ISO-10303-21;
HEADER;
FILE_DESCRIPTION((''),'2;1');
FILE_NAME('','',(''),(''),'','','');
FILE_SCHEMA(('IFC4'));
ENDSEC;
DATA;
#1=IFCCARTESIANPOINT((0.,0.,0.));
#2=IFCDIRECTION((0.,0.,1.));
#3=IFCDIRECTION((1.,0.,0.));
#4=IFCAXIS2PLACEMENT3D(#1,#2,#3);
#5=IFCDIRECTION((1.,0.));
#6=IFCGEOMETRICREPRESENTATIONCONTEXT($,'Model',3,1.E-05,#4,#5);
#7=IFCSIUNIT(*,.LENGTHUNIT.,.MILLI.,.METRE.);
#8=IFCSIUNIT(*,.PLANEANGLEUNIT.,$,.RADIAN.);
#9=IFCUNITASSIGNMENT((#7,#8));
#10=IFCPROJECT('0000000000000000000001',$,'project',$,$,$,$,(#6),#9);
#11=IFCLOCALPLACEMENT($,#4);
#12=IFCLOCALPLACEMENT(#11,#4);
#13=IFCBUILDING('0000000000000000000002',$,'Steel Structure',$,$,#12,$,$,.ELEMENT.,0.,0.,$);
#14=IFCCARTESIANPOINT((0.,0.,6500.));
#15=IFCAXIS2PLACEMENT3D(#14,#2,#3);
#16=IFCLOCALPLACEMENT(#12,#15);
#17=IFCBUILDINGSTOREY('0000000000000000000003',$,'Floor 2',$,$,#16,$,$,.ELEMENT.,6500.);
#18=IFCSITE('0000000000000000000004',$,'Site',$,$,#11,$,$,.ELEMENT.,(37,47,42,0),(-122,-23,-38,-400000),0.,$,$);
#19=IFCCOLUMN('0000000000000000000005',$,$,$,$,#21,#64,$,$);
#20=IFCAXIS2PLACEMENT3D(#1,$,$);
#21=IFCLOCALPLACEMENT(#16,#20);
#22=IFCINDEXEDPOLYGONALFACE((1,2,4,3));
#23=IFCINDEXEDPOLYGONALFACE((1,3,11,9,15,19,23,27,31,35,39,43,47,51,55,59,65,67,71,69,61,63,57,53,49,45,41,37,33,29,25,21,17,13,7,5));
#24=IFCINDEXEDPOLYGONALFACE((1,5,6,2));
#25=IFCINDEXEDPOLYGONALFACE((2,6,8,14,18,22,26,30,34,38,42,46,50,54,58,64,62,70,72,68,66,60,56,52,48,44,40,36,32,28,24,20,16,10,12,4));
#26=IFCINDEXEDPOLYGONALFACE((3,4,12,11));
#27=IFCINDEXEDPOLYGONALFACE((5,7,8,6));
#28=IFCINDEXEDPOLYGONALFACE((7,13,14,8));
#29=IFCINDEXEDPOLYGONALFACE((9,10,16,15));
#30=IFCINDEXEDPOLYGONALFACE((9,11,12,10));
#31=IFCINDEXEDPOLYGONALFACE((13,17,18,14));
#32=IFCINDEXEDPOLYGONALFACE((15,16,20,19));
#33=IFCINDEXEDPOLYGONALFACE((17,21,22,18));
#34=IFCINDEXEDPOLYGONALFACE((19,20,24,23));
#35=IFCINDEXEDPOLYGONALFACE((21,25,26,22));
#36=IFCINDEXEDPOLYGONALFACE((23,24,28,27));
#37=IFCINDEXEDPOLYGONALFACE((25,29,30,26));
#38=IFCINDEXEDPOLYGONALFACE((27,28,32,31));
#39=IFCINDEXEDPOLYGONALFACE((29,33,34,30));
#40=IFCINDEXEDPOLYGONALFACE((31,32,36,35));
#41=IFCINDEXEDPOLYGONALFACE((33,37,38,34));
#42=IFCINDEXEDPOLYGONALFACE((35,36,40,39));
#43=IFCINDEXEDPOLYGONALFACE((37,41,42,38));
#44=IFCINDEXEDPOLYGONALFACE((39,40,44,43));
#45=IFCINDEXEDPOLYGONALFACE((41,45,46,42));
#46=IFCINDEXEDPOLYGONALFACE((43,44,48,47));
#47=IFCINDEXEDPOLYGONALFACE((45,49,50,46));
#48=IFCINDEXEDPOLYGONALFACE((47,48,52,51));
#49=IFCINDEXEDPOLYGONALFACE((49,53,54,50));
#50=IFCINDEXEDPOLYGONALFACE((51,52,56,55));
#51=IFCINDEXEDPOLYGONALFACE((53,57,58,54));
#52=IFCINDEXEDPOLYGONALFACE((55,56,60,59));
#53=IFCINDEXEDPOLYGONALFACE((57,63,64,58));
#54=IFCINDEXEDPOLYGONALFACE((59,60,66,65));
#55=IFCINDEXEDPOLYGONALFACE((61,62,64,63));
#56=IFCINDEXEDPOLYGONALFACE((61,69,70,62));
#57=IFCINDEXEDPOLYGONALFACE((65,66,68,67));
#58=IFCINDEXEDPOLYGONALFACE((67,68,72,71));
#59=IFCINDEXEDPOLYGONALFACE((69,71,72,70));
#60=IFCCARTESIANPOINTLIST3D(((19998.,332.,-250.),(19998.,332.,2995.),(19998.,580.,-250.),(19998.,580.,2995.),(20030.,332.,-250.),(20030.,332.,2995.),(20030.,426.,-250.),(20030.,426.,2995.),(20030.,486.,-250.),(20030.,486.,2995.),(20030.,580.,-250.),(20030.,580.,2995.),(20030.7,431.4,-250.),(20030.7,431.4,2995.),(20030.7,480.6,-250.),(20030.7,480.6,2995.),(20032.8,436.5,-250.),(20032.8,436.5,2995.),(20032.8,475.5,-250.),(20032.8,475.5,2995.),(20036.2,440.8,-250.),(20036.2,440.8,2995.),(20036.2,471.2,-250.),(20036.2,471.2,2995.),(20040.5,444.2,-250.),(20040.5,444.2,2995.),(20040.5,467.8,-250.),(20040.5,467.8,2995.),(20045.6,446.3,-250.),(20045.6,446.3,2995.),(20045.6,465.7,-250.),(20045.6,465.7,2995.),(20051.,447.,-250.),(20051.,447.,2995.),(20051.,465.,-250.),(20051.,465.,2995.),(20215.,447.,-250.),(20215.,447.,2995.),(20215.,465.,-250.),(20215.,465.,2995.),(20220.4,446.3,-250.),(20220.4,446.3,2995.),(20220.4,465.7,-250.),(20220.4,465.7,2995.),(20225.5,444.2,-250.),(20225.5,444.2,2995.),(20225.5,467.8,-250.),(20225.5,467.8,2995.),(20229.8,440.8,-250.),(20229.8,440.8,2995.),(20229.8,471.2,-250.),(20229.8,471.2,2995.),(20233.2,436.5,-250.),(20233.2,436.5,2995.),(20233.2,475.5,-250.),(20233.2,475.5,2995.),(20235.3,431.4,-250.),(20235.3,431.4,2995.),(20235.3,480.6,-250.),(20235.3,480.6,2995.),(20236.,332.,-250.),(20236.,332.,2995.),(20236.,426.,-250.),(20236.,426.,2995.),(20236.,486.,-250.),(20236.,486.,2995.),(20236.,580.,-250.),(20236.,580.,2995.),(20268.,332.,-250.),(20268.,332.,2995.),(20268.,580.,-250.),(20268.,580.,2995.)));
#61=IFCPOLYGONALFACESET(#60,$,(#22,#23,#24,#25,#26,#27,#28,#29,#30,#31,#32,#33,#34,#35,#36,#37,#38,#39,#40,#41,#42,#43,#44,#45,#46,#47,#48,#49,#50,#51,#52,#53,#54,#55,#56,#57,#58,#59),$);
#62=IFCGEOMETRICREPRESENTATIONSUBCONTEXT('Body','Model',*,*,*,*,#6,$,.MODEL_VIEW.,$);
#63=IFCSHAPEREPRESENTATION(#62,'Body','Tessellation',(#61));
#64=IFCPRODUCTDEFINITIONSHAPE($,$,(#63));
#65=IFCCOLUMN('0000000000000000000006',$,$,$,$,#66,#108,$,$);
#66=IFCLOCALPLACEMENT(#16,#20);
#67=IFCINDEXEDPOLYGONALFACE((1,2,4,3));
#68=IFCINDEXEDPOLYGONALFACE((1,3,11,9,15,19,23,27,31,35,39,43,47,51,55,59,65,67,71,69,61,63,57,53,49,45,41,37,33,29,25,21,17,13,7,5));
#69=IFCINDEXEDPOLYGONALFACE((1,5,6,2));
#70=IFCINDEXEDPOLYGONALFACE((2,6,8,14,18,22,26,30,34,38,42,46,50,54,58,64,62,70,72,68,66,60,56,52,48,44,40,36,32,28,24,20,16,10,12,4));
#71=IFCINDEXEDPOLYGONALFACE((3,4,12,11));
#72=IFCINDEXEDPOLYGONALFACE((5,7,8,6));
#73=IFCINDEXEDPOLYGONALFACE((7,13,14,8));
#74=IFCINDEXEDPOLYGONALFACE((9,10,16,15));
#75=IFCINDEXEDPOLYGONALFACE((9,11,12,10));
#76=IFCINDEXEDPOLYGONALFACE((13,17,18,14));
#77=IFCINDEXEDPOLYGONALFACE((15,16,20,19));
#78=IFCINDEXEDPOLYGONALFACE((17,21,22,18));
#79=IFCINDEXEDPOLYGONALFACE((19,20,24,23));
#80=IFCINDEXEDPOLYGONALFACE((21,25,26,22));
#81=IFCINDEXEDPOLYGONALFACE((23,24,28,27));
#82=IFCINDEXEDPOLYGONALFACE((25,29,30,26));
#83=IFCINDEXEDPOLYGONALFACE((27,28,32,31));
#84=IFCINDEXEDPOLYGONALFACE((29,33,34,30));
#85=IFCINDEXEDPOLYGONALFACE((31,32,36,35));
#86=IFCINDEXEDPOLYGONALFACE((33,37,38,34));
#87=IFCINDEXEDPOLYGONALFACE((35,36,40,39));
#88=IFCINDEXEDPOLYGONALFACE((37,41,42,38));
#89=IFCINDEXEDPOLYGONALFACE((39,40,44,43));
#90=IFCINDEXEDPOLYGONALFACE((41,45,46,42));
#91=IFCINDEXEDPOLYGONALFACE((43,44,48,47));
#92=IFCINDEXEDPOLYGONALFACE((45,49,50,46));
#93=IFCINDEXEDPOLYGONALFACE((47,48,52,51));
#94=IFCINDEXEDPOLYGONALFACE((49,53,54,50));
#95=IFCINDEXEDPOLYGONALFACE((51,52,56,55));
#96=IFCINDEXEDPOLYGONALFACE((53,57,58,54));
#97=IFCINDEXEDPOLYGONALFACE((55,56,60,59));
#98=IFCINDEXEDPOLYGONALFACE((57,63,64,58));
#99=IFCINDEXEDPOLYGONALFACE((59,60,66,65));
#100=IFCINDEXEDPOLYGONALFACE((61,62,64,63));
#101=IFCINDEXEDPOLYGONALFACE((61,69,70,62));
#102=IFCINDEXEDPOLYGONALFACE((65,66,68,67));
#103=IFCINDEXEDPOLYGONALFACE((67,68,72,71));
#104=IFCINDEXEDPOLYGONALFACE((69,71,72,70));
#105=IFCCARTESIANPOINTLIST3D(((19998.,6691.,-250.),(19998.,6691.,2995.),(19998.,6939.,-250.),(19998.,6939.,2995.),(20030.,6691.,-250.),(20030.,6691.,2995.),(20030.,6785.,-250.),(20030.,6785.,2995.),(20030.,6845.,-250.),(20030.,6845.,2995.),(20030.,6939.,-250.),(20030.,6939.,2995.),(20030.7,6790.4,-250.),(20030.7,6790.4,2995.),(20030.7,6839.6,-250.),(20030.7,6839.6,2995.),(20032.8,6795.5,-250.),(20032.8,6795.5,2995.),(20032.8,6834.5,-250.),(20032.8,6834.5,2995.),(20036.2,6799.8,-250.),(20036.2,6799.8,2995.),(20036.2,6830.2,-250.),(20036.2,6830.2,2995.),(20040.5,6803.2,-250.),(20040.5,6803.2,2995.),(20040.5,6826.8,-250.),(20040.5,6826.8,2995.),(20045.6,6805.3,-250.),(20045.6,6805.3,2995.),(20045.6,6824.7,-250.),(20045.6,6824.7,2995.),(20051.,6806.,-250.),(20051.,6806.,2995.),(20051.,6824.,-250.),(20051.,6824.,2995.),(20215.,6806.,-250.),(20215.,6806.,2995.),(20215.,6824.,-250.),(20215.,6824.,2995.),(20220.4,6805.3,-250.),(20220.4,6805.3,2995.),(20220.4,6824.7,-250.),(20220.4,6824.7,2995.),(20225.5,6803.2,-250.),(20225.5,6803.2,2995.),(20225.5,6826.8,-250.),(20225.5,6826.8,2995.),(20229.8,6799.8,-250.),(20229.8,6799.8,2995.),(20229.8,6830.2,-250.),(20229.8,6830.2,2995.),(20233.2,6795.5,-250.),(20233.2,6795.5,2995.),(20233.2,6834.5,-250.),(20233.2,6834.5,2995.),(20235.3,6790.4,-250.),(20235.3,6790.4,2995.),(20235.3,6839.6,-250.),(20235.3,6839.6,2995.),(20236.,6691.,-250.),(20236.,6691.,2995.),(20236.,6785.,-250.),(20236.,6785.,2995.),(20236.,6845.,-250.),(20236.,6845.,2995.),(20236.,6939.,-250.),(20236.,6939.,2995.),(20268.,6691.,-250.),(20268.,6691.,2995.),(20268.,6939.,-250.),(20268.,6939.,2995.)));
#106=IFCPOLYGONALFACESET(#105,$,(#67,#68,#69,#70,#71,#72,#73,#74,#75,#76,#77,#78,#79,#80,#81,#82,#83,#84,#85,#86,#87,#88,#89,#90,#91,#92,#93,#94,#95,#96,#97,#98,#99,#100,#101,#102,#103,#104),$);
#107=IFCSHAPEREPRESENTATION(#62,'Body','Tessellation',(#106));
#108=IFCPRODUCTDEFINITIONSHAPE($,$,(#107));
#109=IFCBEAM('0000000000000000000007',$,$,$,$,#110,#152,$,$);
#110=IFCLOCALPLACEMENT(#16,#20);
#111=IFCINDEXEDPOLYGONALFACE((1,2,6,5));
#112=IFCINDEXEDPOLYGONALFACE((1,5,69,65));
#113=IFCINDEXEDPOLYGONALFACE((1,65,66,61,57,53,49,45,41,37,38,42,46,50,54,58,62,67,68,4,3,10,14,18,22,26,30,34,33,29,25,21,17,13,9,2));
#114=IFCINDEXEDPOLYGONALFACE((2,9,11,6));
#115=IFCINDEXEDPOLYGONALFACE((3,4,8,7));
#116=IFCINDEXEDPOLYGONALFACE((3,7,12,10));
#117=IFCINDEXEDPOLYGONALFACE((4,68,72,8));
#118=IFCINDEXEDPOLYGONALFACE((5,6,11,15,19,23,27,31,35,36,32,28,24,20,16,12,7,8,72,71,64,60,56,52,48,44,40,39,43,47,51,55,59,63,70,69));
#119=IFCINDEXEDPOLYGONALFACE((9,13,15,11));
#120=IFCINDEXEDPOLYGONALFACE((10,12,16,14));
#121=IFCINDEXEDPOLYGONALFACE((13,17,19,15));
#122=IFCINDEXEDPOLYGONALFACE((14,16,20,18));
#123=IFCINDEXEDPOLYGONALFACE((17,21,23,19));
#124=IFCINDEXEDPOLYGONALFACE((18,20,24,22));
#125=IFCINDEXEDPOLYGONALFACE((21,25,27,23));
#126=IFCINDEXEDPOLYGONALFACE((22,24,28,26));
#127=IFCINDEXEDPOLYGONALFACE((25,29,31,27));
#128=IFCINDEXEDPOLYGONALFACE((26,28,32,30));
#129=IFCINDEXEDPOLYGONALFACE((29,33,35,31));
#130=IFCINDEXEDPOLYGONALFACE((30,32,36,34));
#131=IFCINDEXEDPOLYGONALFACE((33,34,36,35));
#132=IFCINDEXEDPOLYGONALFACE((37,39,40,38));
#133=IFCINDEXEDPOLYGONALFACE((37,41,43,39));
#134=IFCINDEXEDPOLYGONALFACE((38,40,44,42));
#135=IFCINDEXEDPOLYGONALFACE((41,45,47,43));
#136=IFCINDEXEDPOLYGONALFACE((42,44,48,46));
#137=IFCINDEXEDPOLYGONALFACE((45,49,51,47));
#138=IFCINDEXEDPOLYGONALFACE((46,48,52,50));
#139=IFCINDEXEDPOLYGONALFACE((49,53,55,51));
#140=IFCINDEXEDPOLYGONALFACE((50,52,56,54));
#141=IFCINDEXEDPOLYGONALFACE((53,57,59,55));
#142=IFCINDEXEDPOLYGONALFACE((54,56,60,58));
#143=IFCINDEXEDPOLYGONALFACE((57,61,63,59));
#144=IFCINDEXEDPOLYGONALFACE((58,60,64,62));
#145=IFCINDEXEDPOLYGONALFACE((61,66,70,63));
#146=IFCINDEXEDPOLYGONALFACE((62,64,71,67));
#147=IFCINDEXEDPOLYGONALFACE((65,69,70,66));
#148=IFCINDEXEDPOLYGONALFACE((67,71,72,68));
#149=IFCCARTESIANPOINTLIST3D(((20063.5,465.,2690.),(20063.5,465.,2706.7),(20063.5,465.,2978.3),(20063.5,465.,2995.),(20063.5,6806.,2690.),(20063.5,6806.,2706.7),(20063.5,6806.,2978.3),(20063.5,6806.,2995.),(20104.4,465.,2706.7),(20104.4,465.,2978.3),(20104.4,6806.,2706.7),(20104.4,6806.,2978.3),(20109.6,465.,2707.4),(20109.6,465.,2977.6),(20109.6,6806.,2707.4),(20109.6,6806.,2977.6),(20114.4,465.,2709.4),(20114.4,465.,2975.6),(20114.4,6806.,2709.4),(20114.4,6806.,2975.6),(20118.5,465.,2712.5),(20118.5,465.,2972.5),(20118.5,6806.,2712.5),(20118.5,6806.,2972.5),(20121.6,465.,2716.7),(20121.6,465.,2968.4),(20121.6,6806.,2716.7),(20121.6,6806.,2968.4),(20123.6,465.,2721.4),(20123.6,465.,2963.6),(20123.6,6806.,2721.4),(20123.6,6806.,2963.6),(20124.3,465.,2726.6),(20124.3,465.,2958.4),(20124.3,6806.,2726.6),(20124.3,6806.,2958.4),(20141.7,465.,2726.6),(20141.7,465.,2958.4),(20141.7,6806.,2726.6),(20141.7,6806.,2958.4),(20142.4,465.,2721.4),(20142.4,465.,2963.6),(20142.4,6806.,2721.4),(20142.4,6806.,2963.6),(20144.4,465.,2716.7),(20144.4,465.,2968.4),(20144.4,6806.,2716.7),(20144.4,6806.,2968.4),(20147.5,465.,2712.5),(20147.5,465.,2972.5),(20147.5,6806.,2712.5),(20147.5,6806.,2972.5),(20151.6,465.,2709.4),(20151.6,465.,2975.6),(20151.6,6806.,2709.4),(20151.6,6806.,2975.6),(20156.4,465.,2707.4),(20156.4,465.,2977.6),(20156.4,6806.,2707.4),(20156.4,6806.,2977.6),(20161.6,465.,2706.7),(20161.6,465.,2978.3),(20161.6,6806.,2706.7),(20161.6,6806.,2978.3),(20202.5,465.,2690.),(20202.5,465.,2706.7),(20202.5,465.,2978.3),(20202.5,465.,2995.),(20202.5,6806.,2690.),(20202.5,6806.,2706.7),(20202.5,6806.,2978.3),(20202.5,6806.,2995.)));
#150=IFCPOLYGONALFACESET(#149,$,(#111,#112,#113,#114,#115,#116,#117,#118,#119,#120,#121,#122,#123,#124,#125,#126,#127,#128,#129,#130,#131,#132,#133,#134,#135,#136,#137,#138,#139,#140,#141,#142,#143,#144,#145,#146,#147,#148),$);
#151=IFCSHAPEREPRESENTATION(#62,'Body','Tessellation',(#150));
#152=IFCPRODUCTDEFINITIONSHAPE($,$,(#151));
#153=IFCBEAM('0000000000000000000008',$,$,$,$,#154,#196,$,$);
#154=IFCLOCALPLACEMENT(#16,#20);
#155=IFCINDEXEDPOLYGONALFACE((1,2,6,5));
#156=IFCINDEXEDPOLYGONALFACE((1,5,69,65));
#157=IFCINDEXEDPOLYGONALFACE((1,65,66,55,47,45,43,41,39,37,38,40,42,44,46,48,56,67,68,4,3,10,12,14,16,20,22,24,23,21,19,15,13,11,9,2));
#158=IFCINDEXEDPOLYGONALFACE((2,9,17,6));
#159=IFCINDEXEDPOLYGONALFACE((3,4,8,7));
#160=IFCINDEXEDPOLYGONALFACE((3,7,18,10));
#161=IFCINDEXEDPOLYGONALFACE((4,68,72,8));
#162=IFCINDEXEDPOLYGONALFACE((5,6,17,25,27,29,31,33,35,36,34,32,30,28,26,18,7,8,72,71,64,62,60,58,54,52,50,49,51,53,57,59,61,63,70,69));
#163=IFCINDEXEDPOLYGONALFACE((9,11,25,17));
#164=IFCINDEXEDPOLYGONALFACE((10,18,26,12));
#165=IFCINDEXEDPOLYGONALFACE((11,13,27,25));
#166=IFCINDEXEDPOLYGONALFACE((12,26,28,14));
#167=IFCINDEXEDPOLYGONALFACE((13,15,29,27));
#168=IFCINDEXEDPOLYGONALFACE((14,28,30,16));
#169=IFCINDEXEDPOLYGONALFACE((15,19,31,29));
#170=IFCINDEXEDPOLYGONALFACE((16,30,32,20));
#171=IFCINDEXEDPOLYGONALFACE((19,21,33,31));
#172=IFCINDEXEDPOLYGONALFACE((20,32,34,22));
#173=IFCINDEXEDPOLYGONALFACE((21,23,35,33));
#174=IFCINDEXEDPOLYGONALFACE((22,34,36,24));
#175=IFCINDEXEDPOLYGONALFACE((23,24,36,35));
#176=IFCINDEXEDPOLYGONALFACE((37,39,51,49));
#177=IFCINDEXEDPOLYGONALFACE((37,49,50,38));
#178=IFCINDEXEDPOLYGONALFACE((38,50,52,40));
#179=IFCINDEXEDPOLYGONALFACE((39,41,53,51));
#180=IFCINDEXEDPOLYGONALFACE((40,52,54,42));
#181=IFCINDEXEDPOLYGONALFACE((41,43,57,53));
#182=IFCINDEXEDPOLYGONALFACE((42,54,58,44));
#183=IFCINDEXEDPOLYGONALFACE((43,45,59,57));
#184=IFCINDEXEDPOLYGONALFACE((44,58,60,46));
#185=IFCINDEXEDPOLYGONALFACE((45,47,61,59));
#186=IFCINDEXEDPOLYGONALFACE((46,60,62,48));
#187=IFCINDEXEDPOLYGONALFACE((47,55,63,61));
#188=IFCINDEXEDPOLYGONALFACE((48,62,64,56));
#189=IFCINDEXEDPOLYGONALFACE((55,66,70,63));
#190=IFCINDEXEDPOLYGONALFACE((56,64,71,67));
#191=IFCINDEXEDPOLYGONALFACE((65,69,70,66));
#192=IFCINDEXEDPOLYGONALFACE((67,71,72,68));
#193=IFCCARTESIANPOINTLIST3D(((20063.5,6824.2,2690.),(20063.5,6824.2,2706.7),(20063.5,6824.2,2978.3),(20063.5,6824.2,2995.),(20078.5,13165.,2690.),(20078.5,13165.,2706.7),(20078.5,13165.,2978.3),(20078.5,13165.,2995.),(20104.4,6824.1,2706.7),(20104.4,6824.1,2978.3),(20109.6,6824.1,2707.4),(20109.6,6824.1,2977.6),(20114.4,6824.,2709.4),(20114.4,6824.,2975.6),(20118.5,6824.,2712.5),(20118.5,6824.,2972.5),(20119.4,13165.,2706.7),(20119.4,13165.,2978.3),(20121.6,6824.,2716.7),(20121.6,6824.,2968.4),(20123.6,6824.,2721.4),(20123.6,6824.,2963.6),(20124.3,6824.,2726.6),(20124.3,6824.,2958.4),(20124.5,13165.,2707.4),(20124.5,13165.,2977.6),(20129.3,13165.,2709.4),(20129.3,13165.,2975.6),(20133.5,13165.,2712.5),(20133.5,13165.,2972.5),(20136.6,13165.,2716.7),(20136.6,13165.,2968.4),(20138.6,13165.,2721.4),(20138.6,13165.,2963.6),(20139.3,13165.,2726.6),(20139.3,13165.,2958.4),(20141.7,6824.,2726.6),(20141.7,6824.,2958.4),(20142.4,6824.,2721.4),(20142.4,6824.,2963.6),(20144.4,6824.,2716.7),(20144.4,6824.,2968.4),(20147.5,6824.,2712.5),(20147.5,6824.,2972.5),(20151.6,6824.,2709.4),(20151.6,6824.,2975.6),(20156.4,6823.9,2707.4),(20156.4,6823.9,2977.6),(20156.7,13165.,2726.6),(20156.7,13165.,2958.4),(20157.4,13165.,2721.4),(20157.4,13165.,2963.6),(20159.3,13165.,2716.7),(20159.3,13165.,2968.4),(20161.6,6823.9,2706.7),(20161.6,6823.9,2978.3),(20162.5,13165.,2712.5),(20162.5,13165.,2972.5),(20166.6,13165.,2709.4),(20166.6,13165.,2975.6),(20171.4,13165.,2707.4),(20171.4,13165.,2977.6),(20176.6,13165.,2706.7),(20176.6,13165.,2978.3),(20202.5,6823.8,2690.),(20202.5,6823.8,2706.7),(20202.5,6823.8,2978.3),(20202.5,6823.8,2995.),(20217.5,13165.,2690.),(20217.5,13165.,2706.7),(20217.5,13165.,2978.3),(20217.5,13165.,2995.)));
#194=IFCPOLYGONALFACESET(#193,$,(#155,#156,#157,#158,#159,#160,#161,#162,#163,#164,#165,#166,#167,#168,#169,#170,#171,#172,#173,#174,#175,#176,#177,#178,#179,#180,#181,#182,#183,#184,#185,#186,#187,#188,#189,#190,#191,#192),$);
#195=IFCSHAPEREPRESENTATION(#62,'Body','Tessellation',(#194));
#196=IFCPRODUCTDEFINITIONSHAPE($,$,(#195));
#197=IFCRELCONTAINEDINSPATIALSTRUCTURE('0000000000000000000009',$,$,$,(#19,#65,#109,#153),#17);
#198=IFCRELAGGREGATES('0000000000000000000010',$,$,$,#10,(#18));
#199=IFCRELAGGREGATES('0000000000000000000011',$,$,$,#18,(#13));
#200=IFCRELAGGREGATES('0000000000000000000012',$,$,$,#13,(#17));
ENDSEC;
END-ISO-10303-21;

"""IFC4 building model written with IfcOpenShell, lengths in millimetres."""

from ifc_helpers import new_model, si_unit, direction, frame, origin_with_axes, origin_2d_with_axis, place, context, subcontext, project, spatial, polyline, i_section, extrude, clip, bounded_halfspace, element, save


model = new_model("IFC4")

# Units and contexts
model_context = context("Model", 3, precision=1e-05, world=origin_with_axes(), true_north=direction((1.0, 0.0)))
body_context = subcontext(model_context, "Body", "Model", "MODEL_VIEW")
ifc_project = project(units=[si_unit("LENGTHUNIT", "METRE", prefix="MILLI"), si_unit("PLANEANGLEUNIT", "RADIAN")], contexts=[model_context])

# Site, building, storey
site_placement = place(None, origin_with_axes())
site = spatial("IfcSite", under=ifc_project, at=site_placement, Name="Site", CompositionType="ELEMENT", RefLatitude=(37, 47, 42, 0), RefLongitude=(-122, -23, -38, -400000), RefElevation=0.0)
building_placement = place(site_placement, origin_with_axes())
building = spatial("IfcBuilding", under=site, at=building_placement, Name="Steel Structure", CompositionType="ELEMENT", ElevationOfRefHeight=0.0, ElevationOfTerrain=0.0)
storey_placement = place(building_placement, frame((0.0, 0.0, 6500.0), z_axis=(0.0, 0.0, 1.0), x_axis=(1.0, 0.0, 0.0)))
storey = spatial("IfcBuildingStorey", under=building, at=storey_placement, Name="Floor 2", CompositionType="ELEMENT", Elevation=6500.0)

# Columns
for number, where, z_axis, x_axis in (
    (1, (20133.0, 456.0, -250.0), (0.0, 0.0, 1.0), (0.0, 1.0, 0.0)),
):
    element("IfcColumn", number, at=place(storey_placement, frame(where, z_axis=z_axis, x_axis=x_axis)), inside=storey, context=body_context, shape_type="SweptSolid", body=[
        extrude(i_section(OverallWidth=248.0, OverallDepth=270.0, WebThickness=18.0, FlangeThickness=32.0, FilletRadius=21.0, at=origin_2d_with_axis()), origin_with_axes(), (0.0, 0.0, 1.0), 3245.0),
    ])
column_placement = place(storey_placement, frame((20133.0, 6815.0, -250.0), z_axis=(0.0, 0.0, 1.0), x_axis=(0.0, -1.0, 0.0)))
element("IfcColumn", 2, at=column_placement, inside=storey, context=body_context, shape_type="SweptSolid", body=[
    extrude(i_section(OverallWidth=248.0, OverallDepth=270.0, WebThickness=18.0, FlangeThickness=32.0, FilletRadius=21.0, at=origin_2d_with_axis()), origin_with_axes(), (0.0, 0.0, 1.0), 3245.0),
])

# Beams
beam_1_placement = place(storey_placement, frame((20133.0, 465.0, 2842.5), z_axis=(0.0, 1.0, 0.0), x_axis=(-1.0, 0.0, 0.0)))
element("IfcBeam", 3, at=beam_1_placement, inside=storey, context=body_context, shape_type="SweptSolid", body=[
    extrude(i_section(OverallWidth=139.0, OverallDepth=305.0, WebThickness=17.4, FlangeThickness=16.7, FilletRadius=19.9, at=origin_2d_with_axis()), origin_with_axes(), (0.0, 0.0, 1.0), 6341.0),
])
beam_2_placement = place(storey_placement, frame((20148.0, 13165.2, 2690.0), z_axis=(-0.002362, -0.999997, 0.0), x_axis=(0.999997, -0.002362, 0.0)))
element("IfcBeam", 4, at=beam_2_placement, inside=storey, context=body_context, shape_type="Clipping", body=[
    clip(extrude(i_section(OverallWidth=139.0, OverallDepth=305.0, WebThickness=17.4, FlangeThickness=16.7, FilletRadius=19.9, at=origin_2d_with_axis()), frame((0.0, 152.5, 0.0), z_axis=(0.0, 0.0, 1.0), x_axis=(1.0, 0.0, 0.0)), (0.0, 0.0, 1.0), 6341.2), bounded_halfspace(frame((-20147.9, -9190.0, 47.8), z_axis=(-0.002362, 0.0, -0.999997), x_axis=(-0.999997, 0.0, 0.002362)), False, frame((0.0, 152.5, 0.0), z_axis=(0.0, 0.0, 1.0), x_axis=(1.0, 0.0, 0.0)), polyline([(69.5, 152.5), (69.5, 135.8), (28.6, 135.8), (8.7, 115.9), (8.7, -115.9), (28.6, -135.8), (69.5, -135.8), (69.5, -152.5), (-69.5, -152.5), (-69.5, -135.8), (-28.6, -135.8), (-8.7, -115.9), (-8.7, 115.9), (-28.6, 135.8), (-69.5, 135.8), (-69.5, 152.5), (69.5, 152.5)]))),
])

save(model, "model.ifc")
